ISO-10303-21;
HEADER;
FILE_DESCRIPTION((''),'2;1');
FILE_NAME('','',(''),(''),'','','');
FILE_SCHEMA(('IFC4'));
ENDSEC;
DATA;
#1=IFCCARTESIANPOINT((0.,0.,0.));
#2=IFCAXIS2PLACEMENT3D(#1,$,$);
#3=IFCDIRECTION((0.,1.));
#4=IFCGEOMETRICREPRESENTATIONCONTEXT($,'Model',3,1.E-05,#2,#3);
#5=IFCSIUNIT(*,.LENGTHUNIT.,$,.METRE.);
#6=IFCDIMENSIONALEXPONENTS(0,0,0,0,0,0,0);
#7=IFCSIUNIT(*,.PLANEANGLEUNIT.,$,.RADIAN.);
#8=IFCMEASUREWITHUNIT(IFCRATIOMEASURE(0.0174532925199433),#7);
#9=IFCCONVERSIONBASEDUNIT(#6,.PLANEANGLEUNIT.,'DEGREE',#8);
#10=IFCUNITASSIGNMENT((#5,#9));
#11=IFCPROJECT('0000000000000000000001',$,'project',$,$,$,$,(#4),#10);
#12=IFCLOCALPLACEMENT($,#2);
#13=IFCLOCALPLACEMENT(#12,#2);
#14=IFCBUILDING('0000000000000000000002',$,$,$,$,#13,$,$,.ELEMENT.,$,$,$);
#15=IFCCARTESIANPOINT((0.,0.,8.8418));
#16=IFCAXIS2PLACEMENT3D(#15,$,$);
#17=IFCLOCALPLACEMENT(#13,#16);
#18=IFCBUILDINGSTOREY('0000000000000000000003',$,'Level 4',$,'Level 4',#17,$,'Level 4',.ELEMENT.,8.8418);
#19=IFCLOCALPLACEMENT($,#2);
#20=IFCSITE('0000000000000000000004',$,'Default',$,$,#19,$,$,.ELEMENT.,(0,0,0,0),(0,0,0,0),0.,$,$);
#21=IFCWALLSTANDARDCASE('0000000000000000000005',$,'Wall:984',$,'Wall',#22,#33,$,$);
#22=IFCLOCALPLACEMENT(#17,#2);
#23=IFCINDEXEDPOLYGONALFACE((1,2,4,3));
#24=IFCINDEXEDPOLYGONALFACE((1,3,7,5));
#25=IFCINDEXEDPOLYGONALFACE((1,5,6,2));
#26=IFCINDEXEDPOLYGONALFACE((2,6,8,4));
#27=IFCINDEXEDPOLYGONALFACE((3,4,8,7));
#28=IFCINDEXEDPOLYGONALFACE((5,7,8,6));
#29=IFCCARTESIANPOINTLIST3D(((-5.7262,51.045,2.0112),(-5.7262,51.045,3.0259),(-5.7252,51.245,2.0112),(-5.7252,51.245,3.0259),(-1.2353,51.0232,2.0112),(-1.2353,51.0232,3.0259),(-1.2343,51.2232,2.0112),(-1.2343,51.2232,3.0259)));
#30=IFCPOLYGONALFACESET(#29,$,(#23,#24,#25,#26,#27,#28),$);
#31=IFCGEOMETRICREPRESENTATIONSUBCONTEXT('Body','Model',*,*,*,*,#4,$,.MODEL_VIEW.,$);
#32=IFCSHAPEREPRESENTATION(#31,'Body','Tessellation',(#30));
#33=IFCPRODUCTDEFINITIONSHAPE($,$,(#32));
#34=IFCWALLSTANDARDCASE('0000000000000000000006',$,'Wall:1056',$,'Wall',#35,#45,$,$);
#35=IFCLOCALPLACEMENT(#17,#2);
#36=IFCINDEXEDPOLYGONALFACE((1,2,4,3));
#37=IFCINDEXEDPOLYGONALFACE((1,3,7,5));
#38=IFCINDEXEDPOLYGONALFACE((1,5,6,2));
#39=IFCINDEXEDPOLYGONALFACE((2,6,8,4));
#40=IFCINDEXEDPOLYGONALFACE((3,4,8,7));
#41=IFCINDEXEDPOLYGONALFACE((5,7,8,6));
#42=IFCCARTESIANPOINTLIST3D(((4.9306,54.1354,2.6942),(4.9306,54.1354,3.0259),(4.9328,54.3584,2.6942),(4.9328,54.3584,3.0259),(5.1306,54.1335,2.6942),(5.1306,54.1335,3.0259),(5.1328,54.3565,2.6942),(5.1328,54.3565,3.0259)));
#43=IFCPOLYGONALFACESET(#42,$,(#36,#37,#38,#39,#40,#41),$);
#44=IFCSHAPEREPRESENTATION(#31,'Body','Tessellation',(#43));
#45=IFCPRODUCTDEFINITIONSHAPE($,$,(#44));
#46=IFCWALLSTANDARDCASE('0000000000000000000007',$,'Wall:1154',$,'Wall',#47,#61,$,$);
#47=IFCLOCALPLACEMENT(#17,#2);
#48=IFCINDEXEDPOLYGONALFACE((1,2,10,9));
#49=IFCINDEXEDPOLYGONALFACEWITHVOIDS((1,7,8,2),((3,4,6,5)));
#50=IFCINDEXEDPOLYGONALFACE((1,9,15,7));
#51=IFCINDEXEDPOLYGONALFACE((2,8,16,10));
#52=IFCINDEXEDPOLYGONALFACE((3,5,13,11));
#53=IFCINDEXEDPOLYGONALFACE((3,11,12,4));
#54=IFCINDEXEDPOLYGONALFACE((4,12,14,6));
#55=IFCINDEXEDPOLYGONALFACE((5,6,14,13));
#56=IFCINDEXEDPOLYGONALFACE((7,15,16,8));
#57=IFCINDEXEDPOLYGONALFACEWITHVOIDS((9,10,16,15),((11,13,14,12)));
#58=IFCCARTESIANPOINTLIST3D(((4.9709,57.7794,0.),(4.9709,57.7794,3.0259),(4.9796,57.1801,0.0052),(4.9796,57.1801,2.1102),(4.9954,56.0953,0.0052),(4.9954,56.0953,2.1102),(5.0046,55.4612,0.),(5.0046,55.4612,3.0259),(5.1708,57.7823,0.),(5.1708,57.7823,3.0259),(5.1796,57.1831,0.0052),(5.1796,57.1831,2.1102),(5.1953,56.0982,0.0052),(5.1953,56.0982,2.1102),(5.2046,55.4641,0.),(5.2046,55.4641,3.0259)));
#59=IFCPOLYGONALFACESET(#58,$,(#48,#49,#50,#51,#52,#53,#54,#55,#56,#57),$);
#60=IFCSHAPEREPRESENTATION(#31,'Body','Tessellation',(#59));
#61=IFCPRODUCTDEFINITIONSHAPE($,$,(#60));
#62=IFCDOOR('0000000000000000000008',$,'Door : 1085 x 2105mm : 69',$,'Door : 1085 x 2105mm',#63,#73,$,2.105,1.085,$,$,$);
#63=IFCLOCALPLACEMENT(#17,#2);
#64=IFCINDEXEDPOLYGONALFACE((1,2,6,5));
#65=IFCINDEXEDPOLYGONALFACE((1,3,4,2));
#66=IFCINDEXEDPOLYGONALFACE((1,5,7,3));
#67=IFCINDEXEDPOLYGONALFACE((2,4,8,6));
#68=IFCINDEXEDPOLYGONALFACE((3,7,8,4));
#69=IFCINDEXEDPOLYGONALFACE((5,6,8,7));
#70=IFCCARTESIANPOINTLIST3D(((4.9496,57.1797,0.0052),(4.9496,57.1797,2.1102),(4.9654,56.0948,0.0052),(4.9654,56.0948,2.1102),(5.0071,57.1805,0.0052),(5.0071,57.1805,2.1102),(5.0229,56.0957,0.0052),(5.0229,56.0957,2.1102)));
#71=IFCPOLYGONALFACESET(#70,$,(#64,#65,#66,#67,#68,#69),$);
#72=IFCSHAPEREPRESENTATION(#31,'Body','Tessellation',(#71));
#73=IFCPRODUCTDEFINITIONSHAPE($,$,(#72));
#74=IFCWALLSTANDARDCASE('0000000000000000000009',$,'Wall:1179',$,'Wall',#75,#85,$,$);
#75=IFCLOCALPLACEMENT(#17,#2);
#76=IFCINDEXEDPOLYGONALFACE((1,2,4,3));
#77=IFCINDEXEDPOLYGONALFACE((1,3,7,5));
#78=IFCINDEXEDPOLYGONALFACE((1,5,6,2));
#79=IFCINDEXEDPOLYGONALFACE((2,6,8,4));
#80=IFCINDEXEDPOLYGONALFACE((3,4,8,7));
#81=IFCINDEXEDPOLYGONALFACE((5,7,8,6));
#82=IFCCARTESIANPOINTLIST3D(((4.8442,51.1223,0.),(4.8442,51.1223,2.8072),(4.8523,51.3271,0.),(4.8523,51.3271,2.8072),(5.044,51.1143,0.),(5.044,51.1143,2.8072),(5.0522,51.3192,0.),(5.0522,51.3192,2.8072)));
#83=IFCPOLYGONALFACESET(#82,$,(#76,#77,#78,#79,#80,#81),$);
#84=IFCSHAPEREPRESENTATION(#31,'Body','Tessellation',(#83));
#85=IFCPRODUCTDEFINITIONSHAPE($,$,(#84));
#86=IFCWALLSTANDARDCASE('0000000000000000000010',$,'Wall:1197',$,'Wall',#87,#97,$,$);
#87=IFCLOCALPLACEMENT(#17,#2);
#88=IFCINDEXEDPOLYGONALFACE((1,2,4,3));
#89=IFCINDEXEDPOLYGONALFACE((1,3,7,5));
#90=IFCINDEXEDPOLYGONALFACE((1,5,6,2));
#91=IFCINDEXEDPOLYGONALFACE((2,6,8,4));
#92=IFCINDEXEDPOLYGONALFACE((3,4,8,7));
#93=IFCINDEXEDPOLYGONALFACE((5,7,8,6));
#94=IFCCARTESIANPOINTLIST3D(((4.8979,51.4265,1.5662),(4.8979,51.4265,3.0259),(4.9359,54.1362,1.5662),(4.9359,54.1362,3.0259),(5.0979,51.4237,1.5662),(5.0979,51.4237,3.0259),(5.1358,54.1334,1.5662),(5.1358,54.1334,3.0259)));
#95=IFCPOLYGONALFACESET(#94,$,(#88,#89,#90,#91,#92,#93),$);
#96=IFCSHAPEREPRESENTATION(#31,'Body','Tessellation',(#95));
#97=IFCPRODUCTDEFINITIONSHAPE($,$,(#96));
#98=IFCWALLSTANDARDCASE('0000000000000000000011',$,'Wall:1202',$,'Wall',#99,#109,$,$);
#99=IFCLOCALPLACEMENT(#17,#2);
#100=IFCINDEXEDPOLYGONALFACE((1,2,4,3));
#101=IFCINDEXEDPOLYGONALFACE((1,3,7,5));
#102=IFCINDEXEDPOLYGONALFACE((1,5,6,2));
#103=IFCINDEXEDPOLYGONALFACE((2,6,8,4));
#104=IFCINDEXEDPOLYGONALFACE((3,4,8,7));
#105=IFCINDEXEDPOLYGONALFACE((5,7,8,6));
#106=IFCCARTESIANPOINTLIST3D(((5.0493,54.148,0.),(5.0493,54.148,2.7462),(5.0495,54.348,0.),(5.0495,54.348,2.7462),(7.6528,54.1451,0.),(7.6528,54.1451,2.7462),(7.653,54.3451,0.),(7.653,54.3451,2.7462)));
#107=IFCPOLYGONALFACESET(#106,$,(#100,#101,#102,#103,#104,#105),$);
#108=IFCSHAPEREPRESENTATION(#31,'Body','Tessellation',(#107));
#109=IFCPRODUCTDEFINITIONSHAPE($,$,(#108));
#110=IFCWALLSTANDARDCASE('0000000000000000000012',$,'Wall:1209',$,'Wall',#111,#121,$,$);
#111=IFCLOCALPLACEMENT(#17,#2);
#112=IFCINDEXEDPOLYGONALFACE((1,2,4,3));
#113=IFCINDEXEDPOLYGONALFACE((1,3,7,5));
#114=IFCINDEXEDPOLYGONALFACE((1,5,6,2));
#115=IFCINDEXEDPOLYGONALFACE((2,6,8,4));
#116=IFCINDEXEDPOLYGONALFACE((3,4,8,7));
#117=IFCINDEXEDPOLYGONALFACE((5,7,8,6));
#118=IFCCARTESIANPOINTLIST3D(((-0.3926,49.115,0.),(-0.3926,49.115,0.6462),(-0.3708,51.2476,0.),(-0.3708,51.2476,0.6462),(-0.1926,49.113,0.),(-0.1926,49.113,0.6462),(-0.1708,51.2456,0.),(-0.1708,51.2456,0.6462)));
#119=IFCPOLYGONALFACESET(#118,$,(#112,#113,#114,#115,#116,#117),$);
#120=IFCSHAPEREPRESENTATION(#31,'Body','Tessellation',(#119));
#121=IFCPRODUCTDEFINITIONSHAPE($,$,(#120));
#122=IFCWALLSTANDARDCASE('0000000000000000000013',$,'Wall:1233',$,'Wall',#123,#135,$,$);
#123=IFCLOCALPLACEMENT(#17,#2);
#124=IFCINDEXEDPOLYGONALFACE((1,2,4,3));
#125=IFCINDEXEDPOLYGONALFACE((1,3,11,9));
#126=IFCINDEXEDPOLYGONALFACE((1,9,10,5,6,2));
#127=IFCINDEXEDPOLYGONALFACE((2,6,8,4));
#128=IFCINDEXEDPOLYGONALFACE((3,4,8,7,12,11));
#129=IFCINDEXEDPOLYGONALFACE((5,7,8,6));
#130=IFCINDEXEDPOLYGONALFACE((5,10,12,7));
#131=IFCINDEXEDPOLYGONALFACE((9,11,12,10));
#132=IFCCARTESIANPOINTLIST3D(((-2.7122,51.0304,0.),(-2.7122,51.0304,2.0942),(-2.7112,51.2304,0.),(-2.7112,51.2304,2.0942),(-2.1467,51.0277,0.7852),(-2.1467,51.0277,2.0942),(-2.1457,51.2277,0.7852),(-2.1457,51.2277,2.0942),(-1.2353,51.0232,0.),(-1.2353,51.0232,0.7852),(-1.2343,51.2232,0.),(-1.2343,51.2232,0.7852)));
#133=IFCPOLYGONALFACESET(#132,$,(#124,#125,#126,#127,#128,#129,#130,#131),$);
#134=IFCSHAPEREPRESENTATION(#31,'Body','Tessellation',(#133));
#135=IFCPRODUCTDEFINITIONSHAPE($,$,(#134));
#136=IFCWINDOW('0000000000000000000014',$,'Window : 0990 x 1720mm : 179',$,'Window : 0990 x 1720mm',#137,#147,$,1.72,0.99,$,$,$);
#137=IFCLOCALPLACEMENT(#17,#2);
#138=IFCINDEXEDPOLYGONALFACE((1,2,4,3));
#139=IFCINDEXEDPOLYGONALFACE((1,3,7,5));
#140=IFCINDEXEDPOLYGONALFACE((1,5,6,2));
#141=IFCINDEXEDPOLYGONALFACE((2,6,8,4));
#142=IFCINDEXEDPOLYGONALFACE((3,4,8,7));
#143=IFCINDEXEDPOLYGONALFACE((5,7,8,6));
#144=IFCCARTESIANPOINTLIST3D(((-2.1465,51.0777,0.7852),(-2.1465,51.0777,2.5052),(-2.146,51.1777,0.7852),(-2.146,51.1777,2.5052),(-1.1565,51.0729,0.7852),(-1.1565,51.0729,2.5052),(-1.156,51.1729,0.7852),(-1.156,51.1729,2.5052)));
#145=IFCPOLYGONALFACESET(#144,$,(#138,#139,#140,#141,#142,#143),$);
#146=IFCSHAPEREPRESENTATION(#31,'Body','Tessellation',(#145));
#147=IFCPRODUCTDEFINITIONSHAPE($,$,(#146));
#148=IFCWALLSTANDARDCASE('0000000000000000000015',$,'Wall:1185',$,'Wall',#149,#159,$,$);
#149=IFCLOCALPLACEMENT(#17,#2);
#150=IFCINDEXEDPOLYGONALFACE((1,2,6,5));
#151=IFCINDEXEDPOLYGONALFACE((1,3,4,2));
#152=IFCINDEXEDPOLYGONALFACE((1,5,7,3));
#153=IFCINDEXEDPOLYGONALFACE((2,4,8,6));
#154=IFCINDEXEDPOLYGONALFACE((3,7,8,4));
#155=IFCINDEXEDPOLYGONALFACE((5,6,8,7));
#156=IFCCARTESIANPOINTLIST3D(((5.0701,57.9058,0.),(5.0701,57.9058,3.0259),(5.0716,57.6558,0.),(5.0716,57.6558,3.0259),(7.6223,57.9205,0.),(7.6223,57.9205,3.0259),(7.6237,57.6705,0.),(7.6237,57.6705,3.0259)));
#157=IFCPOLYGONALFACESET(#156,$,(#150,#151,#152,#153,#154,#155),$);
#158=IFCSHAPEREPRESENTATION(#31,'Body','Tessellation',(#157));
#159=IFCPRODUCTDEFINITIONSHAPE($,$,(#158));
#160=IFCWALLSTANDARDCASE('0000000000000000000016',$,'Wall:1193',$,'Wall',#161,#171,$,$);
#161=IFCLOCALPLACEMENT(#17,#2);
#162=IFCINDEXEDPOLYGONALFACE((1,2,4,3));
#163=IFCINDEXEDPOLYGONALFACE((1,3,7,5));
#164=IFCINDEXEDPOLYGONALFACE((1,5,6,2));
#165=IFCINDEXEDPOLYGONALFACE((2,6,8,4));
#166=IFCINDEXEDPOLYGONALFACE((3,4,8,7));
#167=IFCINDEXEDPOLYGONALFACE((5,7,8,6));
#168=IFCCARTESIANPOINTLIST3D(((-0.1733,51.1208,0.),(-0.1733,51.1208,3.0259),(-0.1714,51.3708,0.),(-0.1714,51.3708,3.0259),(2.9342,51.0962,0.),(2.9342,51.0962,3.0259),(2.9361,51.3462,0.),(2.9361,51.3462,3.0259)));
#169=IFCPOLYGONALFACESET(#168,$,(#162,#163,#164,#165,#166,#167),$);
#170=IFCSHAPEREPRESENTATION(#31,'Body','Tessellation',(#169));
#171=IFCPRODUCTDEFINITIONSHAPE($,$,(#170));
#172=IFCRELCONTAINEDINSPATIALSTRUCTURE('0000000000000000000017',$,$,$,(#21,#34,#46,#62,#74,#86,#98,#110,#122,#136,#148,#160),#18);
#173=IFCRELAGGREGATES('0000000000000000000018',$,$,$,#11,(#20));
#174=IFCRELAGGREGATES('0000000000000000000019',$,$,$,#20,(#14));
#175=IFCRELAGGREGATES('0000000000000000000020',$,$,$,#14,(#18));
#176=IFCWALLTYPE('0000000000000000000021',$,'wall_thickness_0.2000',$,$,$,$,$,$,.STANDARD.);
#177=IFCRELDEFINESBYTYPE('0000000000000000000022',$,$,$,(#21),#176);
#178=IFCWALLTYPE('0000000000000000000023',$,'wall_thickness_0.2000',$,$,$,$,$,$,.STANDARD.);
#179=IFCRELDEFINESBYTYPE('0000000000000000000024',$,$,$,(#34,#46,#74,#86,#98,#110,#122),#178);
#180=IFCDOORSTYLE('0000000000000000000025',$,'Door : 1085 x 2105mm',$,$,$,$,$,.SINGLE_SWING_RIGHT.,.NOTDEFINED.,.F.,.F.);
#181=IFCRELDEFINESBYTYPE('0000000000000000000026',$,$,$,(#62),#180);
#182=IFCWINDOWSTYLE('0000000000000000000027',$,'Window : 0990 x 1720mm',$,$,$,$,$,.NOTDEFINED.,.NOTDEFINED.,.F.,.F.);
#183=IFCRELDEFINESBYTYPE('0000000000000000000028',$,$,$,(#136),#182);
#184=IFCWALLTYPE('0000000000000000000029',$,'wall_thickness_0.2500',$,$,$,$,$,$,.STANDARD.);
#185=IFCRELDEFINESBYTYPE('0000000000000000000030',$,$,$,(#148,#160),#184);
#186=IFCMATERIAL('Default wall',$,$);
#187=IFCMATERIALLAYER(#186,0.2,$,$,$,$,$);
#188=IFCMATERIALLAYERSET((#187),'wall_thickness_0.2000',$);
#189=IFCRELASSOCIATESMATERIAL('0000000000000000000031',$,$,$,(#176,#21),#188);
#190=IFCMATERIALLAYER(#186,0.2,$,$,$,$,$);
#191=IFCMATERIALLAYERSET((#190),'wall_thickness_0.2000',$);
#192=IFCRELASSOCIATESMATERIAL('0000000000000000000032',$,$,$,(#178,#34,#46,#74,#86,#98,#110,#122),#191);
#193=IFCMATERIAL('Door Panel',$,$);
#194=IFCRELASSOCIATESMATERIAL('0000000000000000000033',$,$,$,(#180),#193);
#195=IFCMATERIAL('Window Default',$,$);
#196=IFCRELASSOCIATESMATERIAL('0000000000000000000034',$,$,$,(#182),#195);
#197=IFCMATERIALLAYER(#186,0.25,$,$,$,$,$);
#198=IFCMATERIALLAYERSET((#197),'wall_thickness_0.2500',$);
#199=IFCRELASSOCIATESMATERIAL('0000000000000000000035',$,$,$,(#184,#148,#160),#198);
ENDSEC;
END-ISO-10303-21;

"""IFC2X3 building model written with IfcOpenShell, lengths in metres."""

from ifc_helpers import new_model, entity, si_unit, converted_unit, direction, frame, frame_2d, origin, origin_2d_with_axis, place, context, subcontext, project, spatial, polyline, rectangle, outline, extrude, source, transform, mapped, material, layer, layer_set, layer_usage, type_object, type_shapes, element, fill, save


model = new_model("IFC2X3")

# Units and contexts
model_context = context("Model", 3, precision=1e-05, world=origin(), true_north=direction((0.0, 1.0)))
body_context = subcontext(model_context, "Body", "Model", "MODEL_VIEW")
ifc_project = project(units=[si_unit("LENGTHUNIT", "METRE"), converted_unit("PLANEANGLEUNIT", "DEGREE", entity("IfcRatioMeasure", 0.0174532925199433), si_unit("PLANEANGLEUNIT", "RADIAN"), dimensions=[0, 0, 0, 0, 0, 0, 0])], contexts=[model_context])

# Site, building, storey
site_placement = place(None, origin())
site = spatial("IfcSite", under=ifc_project, at=site_placement, Name="Default", CompositionType="ELEMENT", RefLatitude=(0, 0, 0, 0), RefLongitude=(0, 0, 0, 0), RefElevation=0.0)
placement_1 = place(None, origin())
building_placement = place(placement_1, origin())
building = spatial("IfcBuilding", under=site, at=building_placement, CompositionType="ELEMENT")
storey_placement = place(building_placement, frame((0.0, 0.0, 8.8418)))
storey = spatial("IfcBuildingStorey", under=building, at=storey_placement, Name="Level 4", ObjectType="Level 4", LongName="Level 4", CompositionType="ELEMENT", Elevation=8.8418)

# Walls
ifc_material_1 = material(Name="Default wall")
ifc_layer_1 = layer(ifc_material_1, 0.2)
ifc_layer_set_1 = layer_set([ifc_layer_1], Name="wall_thickness_0.2000")
ifc_layer_usage_1 = layer_usage(ifc_layer_set_1, "AXIS2", "POSITIVE", -0.1)
wall_type_1 = type_object("IfcWallType", Name="wall_thickness_0.2000", PredefinedType="STANDARD", material=ifc_layer_set_1)
placement_2 = place(building_placement, frame((0.0, 0.0, 10.853)))
wall_1_placement = place(placement_2, frame((-5.7257, 51.145, 0.0), z_axis=(0.0, 0.0, 1.0), x_axis=(0.999988, -0.004855, 0.0)))
element("IfcWallStandardCase", 1, at=wall_1_placement, inside=storey, type_object=wall_type_1, material=ifc_layer_usage_1, Name="Wall:984", ObjectType="Wall", context=body_context, shape_type="SweptSolid", body=[
    extrude(outline(polyline([(4.491, -0.1), (4.491, 0.1), (0.0, 0.1), (0.0, -0.1), (4.491, -0.1)])), origin(), (0.0, 0.0, 1.0), 1.0147),
])
ifc_layer_2 = layer(ifc_material_1, 0.2)
ifc_layer_set_2 = layer_set([ifc_layer_2], Name="wall_thickness_0.2000")
ifc_layer_usage_2 = layer_usage(ifc_layer_set_2, "AXIS2", "POSITIVE", -0.1)
wall_type_2 = type_object("IfcWallType", Name="wall_thickness_0.2000", PredefinedType="STANDARD", material=ifc_layer_set_2)
placement_3 = place(building_placement, frame((0.0, 0.0, 11.536)))
wall_2_placement = place(placement_3, frame((5.0328, 54.3574, 0.0), z_axis=(0.0, 0.0, 1.0), x_axis=(-0.009771, -0.999952, 0.0)))
element("IfcWallStandardCase", 2, at=wall_2_placement, inside=storey, type_object=wall_type_2, material=ifc_layer_usage_2, Name="Wall:1056", ObjectType="Wall", context=body_context, shape_type="SweptSolid", body=[
    extrude(outline(polyline([(0.223, -0.1), (0.223, 0.1), (0.0, 0.1), (0.0, -0.1), (0.223, -0.1)])), origin(), (0.0, 0.0, 1.0), 0.3317),
])

# Wall, opening, door
wall_3_placement = place(storey_placement, frame((5.1046, 55.4626, 0.0), z_axis=(0.0, 0.0, 1.0), x_axis=(-0.014548, 0.999894, 0.0)))
wall_3 = element("IfcWallStandardCase", 3, at=wall_3_placement, inside=storey, type_object=wall_type_2, material=ifc_layer_usage_2, Name="Wall:1154", ObjectType="Wall", context=body_context, shape_type="SweptSolid", body=[
    extrude(outline(polyline([(2.3184, -0.1), (2.3184, 0.1), (0.0, 0.1), (0.0, -0.1), (2.3184, -0.1)])), origin(), (0.0, 0.0, 1.0), 3.0259),
])
opening_1_placement = place(wall_3_placement, frame((0.6341, -0.1, 0.0052)))
opening_1 = element("IfcOpeningElement", 4, at=opening_1_placement, cuts=wall_3, ObjectType="Opening", context=body_context, shape_type="SweptSolid", body=[
    extrude(rectangle(XDim=1.085, YDim=2.105, at=frame_2d((1.0525, 0.5425), x_axis=(0.0, 1.0))), frame((0.0, 0.0, 0.0), z_axis=(0.0, 1.0, 0.0), x_axis=(0.0, 0.0, 1.0)), (0.0, 0.0, 1.0), 0.2),
])
ifc_material_2 = material(Name="Door Panel")
door_style_1 = type_object("IfcDoorStyle", Name="Door : 1085 x 2105mm", ConstructionType="NOTDEFINED", OperationType="SINGLE_SWING_RIGHT", ParameterTakesPrecedence=False, Sizeable=False, material=ifc_material_2)
shared_shape_1 = source(origin(), body_context, "Body", "SweptSolid", [
    extrude(rectangle(XDim=0.0575, YDim=1.085, at=origin_2d_with_axis()), frame((0.5425, 0.2013, 0.0), z_axis=(0.0, 0.0, 1.0), x_axis=(0.0, 1.0, 0.0)), (0.0, 0.0, 1.0), 2.105),
])
type_shapes(door_style_1, [shared_shape_1])
door_1_placement = place(opening_1_placement, origin())
door_1 = element("IfcDoor", 5, at=door_1_placement, inside=storey, type_object=door_style_1, Name="Door : 1085 x 2105mm : 69", ObjectType="Door : 1085 x 2105mm", OverallHeight=2.105, OverallWidth=1.085, context=body_context, shape_type="MappedRepresentation", body=[
    mapped(shared_shape_1, transform((0.0, 0.0, 0.0), scale=1.0)),
])
fill(opening_1, door_1)

# Walls
wall_4_placement = place(storey_placement, frame((4.9522, 51.3232, 0.0), z_axis=(0.0, 0.0, 1.0), x_axis=(-0.03964, -0.999214, 0.0)))
element("IfcWallStandardCase", 6, at=wall_4_placement, inside=storey, type_object=wall_type_2, material=ifc_layer_usage_2, Name="Wall:1179", ObjectType="Wall", context=body_context, shape_type="SweptSolid", body=[
    extrude(outline(polyline([(0.205, -0.1), (0.205, 0.1), (0.0, 0.1), (0.0, -0.1), (0.205, -0.1)])), origin(), (0.0, 0.0, 1.0), 2.8072),
])
placement_4 = place(building_placement, frame((0.0, 0.0, 10.408)))
wall_5_placement = place(placement_4, frame((5.0359, 54.1348, 0.0), z_axis=(0.0, 0.0, 1.0), x_axis=(-0.014011, -0.999902, 0.0)))
element("IfcWallStandardCase", 7, at=wall_5_placement, inside=storey, type_object=wall_type_2, material=ifc_layer_usage_2, Name="Wall:1197", ObjectType="Wall", context=body_context, shape_type="SweptSolid", body=[
    extrude(outline(polyline([(2.71, -0.1), (2.71, 0.1), (0.0, 0.1), (0.0, -0.1), (2.71, -0.1)])), origin(), (0.0, 0.0, 1.0), 1.4597),
])
wall_6_placement = place(storey_placement, frame((5.0494, 54.248, 0.0), z_axis=(0.0, 0.0, 1.0), x_axis=(0.999999, -0.00109, 0.0)))
element("IfcWallStandardCase", 8, at=wall_6_placement, inside=storey, type_object=wall_type_2, material=ifc_layer_usage_2, Name="Wall:1202", ObjectType="Wall", context=body_context, shape_type="SweptSolid", body=[
    extrude(outline(polyline([(2.6035, -0.1), (2.6035, 0.1), (0.0, 0.1), (0.0, -0.1), (2.6035, -0.1)])), origin(), (0.0, 0.0, 1.0), 2.7462),
])
wall_7_placement = place(storey_placement, frame((-0.2708, 51.2466, 0.0), z_axis=(0.0, 0.0, 1.0), x_axis=(-0.010213, -0.999948, 0.0)))
element("IfcWallStandardCase", 9, at=wall_7_placement, inside=storey, type_object=wall_type_2, material=ifc_layer_usage_2, Name="Wall:1209", ObjectType="Wall", context=body_context, shape_type="SweptSolid", body=[
    extrude(outline(polyline([(2.1327, -0.1), (2.1327, 0.1), (0.0, 0.1), (0.0, -0.1), (2.1327, -0.1)])), origin(), (0.0, 0.0, 1.0), 0.6462),
])

# Wall, opening, window
wall_8_placement = place(storey_placement, frame((-2.7117, 51.1304, 0.0), z_axis=(0.0, 0.0, 1.0), x_axis=(0.999988, -0.004851, 0.0)))
wall_8 = element("IfcWallStandardCase", 10, at=wall_8_placement, inside=storey, type_object=wall_type_2, material=ifc_layer_usage_2, Name="Wall:1233", ObjectType="Wall", context=body_context, shape_type="SweptSolid", body=[
    extrude(outline(polyline([(1.4769, -0.1), (1.4769, 0.1), (0.0, 0.1), (0.0, -0.1), (1.4769, -0.1)])), origin(), (0.0, 0.0, 1.0), 2.0942),
])
opening_2_placement = place(wall_8_placement, frame((0.5655, -0.1, 0.7852)))
opening_2 = element("IfcOpeningElement", 11, at=opening_2_placement, cuts=wall_8, ObjectType="Opening", context=body_context, shape_type="SweptSolid", body=[
    extrude(rectangle(XDim=0.99, YDim=1.72, at=frame_2d((0.86, 0.495), x_axis=(0.0, 1.0))), frame((0.0, 0.0, 0.0), z_axis=(0.0, 1.0, 0.0), x_axis=(0.0, 0.0, 1.0)), (0.0, 0.0, 1.0), 0.2),
])
ifc_material_3 = material(Name="Window Default")
window_style = type_object("IfcWindowStyle", Name="Window : 0990 x 1720mm", ConstructionType="NOTDEFINED", OperationType="NOTDEFINED", ParameterTakesPrecedence=False, Sizeable=False, material=ifc_material_3)
shared_shape_2 = source(origin(), body_context, "Body", "SweptSolid", [
    extrude(rectangle(XDim=0.1, YDim=0.99, at=origin_2d_with_axis()), frame((0.495, 0.1, 0.0), z_axis=(0.0, 0.0, 1.0), x_axis=(0.0, 1.0, 0.0)), (0.0, 0.0, 1.0), 1.72),
])
type_shapes(window_style, [shared_shape_2])
window_placement = place(opening_2_placement, origin())
window = element("IfcWindow", 12, at=window_placement, inside=storey, type_object=window_style, Name="Window : 0990 x 1720mm : 179", ObjectType="Window : 0990 x 1720mm", OverallHeight=1.72, OverallWidth=0.99, context=body_context, shape_type="MappedRepresentation", body=[
    mapped(shared_shape_2, transform((0.0, 0.0, 0.0), scale=1.0)),
])
fill(opening_2, window)

# Walls
ifc_layer_3 = layer(ifc_material_1, 0.25)
ifc_layer_set_3 = layer_set([ifc_layer_3], Name="wall_thickness_0.2500")
ifc_layer_usage_3 = layer_usage(ifc_layer_set_3, "AXIS2", "POSITIVE", -0.125)
wall_type_3 = type_object("IfcWallType", Name="wall_thickness_0.2500", PredefinedType="STANDARD", material=ifc_layer_set_3)
wall_9_placement = place(storey_placement, frame((5.0709, 57.7808, 0.0), z_axis=(0.0, 0.0, 1.0), x_axis=(0.999983, 0.005767, 0.0)))
element("IfcWallStandardCase", 13, at=wall_9_placement, inside=storey, type_object=wall_type_3, material=ifc_layer_usage_3, Name="Wall:1185", ObjectType="Wall", context=body_context, shape_type="SweptSolid", body=[
    extrude(outline(polyline([(2.5522, -0.125), (2.5522, 0.125), (0.0, 0.125), (0.0, -0.125), (2.5522, -0.125)])), origin(), (0.0, 0.0, 1.0), 3.0259),
])
wall_10_placement = place(storey_placement, frame((-0.1723, 51.2458, 0.0), z_axis=(0.0, 0.0, 1.0), x_axis=(0.999969, -0.007932, 0.0)))
element("IfcWallStandardCase", 14, at=wall_10_placement, inside=storey, type_object=wall_type_3, material=ifc_layer_usage_3, Name="Wall:1193", ObjectType="Wall", context=body_context, shape_type="SweptSolid", body=[
    extrude(outline(polyline([(3.1076, -0.125), (3.1076, 0.125), (0.0, 0.125), (0.0, -0.125), (3.1076, -0.125)])), origin(), (0.0, 0.0, 1.0), 3.0259),
])

save(model, "model.ifc")
